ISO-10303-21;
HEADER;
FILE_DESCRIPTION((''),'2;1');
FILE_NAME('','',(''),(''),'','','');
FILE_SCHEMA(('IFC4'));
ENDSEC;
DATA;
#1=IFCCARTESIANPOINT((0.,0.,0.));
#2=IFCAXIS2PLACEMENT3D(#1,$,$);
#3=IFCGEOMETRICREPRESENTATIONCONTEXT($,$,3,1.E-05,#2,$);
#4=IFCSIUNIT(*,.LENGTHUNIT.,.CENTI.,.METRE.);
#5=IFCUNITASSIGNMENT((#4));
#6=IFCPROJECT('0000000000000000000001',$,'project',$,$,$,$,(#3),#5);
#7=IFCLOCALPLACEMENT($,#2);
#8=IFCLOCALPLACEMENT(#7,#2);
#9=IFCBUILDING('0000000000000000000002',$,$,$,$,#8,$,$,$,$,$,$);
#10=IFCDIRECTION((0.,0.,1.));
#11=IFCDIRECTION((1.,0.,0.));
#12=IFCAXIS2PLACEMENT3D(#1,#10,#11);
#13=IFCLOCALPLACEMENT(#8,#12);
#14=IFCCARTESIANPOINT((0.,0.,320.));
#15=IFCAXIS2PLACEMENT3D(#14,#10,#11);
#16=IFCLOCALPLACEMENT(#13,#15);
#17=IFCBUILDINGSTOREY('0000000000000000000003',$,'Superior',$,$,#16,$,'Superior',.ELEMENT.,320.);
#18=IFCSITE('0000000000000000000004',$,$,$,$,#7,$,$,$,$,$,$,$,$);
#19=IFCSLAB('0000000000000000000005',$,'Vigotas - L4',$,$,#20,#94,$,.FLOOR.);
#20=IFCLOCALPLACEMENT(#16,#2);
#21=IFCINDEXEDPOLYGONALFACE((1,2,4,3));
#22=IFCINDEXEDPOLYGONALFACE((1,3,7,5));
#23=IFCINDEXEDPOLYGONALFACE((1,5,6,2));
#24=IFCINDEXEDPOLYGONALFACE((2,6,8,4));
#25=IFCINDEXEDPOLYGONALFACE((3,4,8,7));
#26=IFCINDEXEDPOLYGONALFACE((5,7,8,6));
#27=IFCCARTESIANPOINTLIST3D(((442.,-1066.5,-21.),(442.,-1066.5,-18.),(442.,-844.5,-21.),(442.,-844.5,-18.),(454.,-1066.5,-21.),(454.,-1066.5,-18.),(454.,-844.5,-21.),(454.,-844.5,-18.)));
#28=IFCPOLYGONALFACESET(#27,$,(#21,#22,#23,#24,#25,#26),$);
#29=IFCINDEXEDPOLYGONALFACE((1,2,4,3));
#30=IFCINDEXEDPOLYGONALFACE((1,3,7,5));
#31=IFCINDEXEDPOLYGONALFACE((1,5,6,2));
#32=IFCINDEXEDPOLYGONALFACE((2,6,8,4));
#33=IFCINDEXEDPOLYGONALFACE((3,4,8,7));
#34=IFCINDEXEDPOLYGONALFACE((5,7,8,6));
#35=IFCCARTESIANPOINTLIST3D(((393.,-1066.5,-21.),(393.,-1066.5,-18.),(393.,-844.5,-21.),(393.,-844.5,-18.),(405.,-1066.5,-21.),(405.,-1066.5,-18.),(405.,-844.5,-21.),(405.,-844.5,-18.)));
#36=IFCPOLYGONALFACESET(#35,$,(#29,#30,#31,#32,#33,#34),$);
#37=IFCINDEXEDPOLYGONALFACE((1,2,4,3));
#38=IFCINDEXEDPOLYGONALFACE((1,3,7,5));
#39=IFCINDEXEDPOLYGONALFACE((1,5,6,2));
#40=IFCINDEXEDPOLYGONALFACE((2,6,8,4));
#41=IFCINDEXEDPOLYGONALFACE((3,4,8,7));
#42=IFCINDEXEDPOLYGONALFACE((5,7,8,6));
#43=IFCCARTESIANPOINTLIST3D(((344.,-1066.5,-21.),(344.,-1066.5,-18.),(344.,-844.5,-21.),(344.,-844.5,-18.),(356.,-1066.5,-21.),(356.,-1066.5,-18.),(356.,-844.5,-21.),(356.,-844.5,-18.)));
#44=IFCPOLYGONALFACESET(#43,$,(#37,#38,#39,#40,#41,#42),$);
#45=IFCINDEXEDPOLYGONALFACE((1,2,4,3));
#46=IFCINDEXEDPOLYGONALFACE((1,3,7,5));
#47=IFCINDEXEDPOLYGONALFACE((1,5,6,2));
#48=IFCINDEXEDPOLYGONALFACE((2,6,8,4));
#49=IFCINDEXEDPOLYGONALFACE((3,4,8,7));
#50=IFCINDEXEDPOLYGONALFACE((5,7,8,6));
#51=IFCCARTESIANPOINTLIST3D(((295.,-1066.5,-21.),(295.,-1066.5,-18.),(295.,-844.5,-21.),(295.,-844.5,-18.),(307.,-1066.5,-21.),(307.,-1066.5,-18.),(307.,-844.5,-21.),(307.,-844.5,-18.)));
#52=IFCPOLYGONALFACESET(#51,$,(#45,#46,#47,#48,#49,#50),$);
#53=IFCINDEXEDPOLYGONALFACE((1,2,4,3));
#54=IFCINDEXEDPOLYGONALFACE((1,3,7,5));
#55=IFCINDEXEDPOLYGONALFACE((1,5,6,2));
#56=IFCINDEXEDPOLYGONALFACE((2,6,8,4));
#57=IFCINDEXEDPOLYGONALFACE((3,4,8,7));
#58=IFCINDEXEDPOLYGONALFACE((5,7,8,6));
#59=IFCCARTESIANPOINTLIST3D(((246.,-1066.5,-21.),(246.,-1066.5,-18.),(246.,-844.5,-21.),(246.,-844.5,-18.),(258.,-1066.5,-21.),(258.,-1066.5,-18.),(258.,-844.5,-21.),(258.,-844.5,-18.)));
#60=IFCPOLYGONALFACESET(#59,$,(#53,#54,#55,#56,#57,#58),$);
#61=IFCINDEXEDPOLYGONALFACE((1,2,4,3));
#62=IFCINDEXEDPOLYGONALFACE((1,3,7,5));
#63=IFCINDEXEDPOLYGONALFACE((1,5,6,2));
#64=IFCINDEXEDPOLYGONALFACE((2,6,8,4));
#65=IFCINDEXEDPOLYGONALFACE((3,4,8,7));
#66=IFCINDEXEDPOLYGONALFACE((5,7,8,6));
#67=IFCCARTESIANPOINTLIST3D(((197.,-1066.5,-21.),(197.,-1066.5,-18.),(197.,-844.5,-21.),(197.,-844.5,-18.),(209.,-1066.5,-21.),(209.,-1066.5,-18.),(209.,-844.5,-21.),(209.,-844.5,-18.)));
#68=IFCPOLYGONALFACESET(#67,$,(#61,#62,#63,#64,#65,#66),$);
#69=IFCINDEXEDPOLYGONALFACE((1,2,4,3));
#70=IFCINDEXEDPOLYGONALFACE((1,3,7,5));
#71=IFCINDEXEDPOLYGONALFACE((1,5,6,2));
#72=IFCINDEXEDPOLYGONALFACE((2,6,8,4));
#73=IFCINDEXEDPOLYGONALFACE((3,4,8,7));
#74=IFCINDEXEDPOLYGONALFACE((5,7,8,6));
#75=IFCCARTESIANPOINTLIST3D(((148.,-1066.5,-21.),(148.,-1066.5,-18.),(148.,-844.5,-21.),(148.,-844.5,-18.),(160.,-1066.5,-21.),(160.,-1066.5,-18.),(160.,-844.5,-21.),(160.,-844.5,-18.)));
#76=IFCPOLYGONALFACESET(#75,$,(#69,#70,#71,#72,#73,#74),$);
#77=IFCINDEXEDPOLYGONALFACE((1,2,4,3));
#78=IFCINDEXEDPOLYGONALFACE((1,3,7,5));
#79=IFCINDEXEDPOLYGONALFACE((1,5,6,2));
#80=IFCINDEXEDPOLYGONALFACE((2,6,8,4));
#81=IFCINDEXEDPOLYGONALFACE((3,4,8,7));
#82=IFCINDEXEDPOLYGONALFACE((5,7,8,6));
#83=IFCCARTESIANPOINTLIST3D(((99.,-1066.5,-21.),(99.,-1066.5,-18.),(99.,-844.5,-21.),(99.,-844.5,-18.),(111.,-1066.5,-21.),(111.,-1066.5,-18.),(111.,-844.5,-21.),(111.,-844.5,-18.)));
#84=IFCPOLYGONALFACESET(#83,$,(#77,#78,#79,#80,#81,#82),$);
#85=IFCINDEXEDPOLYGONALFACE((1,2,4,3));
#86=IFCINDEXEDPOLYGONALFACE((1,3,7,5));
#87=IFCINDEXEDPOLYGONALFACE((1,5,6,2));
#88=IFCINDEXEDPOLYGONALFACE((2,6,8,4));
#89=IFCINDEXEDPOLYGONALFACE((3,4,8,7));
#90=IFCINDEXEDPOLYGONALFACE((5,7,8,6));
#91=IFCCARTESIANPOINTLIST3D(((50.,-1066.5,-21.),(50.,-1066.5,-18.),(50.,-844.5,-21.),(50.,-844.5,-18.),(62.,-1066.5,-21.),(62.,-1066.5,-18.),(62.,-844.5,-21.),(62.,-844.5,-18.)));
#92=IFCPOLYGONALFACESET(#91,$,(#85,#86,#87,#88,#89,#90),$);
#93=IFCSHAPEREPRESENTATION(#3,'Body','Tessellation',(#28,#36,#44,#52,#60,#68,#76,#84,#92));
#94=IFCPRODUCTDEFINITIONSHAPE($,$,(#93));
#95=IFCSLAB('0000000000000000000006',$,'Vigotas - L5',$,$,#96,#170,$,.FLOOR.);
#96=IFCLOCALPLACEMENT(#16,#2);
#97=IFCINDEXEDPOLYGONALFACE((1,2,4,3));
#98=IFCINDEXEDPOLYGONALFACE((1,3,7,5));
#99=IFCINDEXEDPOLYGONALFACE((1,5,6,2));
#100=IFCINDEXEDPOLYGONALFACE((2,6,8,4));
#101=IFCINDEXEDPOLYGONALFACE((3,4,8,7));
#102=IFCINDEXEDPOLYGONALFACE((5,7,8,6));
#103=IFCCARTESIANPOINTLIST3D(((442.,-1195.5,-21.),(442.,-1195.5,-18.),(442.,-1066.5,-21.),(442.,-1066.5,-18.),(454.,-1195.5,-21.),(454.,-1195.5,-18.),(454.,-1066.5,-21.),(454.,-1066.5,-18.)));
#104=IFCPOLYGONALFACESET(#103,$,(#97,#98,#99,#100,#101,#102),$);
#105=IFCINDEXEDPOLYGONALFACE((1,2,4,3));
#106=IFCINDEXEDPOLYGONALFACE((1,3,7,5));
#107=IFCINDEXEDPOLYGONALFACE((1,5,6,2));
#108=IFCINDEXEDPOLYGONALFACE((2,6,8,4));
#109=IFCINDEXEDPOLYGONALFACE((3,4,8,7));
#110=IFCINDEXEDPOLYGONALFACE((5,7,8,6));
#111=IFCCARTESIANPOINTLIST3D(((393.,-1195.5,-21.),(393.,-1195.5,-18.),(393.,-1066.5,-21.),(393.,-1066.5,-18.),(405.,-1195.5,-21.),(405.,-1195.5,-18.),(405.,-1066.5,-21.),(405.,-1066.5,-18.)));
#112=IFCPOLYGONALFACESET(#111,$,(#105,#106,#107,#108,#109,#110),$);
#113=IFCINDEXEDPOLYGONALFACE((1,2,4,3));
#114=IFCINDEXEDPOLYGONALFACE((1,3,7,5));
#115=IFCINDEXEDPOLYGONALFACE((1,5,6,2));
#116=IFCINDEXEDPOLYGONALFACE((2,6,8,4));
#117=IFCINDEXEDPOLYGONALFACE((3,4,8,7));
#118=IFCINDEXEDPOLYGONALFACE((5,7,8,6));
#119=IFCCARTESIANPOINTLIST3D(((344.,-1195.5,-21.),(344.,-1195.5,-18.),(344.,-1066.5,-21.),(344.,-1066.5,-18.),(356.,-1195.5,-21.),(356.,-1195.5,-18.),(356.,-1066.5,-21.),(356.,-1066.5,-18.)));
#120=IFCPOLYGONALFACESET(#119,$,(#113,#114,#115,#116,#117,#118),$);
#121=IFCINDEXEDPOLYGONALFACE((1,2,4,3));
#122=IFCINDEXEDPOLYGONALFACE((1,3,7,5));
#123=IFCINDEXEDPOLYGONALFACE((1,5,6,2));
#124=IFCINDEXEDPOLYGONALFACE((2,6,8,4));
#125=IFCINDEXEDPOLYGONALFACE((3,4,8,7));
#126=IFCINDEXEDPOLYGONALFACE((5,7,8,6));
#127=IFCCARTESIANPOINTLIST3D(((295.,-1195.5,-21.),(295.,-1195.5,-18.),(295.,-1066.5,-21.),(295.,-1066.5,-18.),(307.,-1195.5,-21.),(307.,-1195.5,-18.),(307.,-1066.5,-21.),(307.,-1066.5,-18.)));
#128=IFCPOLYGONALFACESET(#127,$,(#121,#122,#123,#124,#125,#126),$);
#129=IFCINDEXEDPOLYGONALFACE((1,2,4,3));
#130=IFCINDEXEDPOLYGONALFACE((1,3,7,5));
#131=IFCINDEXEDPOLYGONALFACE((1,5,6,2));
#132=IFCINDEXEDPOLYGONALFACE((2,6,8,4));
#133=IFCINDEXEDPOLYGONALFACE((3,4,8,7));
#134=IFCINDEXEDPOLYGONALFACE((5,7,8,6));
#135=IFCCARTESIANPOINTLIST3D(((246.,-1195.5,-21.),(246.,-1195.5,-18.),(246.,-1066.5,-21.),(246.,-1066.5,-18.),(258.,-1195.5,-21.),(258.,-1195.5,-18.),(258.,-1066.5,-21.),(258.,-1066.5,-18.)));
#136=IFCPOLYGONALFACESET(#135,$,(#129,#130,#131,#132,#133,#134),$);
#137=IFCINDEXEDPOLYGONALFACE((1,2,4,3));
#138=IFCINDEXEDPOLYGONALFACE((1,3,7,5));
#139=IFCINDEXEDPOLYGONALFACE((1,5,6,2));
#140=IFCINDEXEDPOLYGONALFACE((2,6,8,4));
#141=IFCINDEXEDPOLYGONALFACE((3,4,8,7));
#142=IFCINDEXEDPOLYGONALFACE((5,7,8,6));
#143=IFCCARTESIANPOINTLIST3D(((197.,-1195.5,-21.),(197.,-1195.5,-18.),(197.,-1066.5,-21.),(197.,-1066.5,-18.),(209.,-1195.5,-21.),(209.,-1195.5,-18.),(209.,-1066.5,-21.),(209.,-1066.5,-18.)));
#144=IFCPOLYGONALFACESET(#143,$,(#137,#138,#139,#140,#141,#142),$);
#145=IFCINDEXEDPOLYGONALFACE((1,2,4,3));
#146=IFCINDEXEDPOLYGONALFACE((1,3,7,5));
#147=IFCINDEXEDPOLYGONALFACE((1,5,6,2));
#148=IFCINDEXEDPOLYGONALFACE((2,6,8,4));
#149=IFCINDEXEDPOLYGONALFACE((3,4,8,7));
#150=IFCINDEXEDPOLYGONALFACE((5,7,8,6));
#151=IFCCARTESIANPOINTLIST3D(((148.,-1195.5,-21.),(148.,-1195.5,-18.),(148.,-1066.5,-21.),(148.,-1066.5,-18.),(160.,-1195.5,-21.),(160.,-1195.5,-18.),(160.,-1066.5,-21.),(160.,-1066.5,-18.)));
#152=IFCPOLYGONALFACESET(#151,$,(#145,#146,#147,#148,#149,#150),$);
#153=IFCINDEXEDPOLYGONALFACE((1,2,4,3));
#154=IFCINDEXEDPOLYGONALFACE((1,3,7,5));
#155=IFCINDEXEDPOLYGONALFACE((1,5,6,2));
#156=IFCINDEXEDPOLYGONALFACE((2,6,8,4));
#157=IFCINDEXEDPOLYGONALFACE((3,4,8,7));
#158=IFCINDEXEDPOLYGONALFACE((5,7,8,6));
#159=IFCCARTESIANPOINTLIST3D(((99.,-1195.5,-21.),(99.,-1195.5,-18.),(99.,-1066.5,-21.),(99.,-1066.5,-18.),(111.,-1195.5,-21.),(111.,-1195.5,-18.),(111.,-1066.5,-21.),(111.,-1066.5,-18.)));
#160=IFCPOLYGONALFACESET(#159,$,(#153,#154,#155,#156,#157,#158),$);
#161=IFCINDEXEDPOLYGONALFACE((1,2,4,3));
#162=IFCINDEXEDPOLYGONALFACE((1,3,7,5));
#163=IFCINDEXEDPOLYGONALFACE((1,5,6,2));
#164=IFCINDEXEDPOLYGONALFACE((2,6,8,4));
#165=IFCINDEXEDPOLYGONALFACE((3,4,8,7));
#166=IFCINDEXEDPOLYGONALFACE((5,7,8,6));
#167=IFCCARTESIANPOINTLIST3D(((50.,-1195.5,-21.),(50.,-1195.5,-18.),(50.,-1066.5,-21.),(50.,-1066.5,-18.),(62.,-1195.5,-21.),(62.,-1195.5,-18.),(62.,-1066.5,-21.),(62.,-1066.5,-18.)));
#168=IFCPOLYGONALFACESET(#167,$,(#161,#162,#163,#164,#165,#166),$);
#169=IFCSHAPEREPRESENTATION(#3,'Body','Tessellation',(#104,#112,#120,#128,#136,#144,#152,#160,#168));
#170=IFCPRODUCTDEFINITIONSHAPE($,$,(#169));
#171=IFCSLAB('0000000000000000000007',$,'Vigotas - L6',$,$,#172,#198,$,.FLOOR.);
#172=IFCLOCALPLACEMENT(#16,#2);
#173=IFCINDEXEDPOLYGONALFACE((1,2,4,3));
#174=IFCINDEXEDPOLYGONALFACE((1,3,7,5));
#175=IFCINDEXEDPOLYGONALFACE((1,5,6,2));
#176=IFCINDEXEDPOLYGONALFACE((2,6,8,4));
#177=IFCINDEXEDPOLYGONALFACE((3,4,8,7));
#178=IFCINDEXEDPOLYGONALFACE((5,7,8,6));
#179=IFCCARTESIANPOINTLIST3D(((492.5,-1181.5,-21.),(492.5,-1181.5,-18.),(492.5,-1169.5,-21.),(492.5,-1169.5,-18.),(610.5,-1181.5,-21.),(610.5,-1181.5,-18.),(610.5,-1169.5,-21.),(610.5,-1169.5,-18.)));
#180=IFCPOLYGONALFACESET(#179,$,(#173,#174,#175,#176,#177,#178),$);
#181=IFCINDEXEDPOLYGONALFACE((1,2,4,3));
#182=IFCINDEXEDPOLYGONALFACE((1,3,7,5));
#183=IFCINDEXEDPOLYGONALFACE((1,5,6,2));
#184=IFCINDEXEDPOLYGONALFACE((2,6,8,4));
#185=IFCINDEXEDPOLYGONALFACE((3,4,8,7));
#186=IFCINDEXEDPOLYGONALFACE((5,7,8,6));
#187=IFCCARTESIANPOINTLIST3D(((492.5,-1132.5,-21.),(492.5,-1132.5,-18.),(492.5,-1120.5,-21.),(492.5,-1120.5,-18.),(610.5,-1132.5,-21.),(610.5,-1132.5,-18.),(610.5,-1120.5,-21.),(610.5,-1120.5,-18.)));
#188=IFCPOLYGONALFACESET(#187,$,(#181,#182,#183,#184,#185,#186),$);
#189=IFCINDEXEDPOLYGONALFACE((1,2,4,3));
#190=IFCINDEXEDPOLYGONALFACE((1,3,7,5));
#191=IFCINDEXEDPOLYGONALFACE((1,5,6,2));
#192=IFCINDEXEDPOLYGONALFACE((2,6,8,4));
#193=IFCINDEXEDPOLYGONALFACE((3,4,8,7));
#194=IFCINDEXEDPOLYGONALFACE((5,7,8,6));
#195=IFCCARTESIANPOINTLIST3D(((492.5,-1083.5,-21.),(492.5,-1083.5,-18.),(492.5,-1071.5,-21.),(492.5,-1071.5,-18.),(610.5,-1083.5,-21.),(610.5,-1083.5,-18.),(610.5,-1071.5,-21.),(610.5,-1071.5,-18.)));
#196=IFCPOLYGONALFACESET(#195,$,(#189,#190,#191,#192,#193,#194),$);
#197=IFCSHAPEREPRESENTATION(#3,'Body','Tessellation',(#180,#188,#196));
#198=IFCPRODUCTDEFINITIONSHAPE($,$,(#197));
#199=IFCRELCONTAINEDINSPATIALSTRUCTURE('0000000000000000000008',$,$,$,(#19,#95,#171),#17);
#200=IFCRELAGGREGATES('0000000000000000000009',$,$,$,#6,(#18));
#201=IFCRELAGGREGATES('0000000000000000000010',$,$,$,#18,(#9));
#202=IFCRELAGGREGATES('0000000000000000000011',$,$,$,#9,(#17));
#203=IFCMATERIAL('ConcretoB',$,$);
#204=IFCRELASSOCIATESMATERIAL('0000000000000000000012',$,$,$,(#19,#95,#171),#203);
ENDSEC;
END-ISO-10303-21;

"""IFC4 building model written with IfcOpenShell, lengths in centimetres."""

from ifc_helpers import new_model, si_unit, frame, origin, origin_with_axes, place, context, project, spatial, polyline, outline, extrude, material, element, save


model = new_model("IFC4")

# Units and contexts
context_of_model = context(None, 3, precision=1e-05, world=origin())
ifc_project = project(units=[si_unit("LENGTHUNIT", "METRE", prefix="CENTI")], contexts=[context_of_model])

# Site, building, storey
site_placement = place(None, origin())
site = spatial("IfcSite", under=ifc_project, at=site_placement)
building_placement = place(site_placement, origin())
building = spatial("IfcBuilding", under=site, at=building_placement)
placement = place(building_placement, origin_with_axes())
storey_placement = place(placement, frame((0.0, 0.0, 320.0), z_axis=(0.0, 0.0, 1.0), x_axis=(1.0, 0.0, 0.0)))
storey = spatial("IfcBuildingStorey", under=building, at=storey_placement, Name="Superior", LongName="Superior", CompositionType="ELEMENT", Elevation=320.0)

# Shared definitions
ifc_material = material(Name="ConcretoB")

# Slabs
slab_1_placement = place(storey_placement, frame((252.0, -955.5, -18.0), z_axis=(0.0, 0.0, 1.0), x_axis=(1.0, 0.0, 0.0)))
element("IfcSlab", 1, at=slab_1_placement, inside=storey, material=ifc_material, Name="Vigotas - L4", PredefinedType="FLOOR", context=context_of_model, shape_type="SolidModel", body=[
    extrude(outline(polyline([(6.0, 1.5), (-6.0, 1.5), (-6.0, -1.5), (6.0, -1.5), (6.0, 1.5), (6.0, 1.5)])), frame((196.0, -111.0, -1.5), z_axis=(0.0, 1.0, 0.0), x_axis=(1.0, 0.0, 0.0)), (0.0, 0.0, 1.0), 222.0),
    extrude(outline(polyline([(6.0, 1.5), (-6.0, 1.5), (-6.0, -1.5), (6.0, -1.5), (6.0, 1.5), (6.0, 1.5)])), frame((147.0, -111.0, -1.5), z_axis=(0.0, 1.0, 0.0), x_axis=(1.0, 0.0, 0.0)), (0.0, 0.0, 1.0), 222.0),
    extrude(outline(polyline([(6.0, 1.5), (-6.0, 1.5), (-6.0, -1.5), (6.0, -1.5), (6.0, 1.5), (6.0, 1.5)])), frame((98.0, -111.0, -1.5), z_axis=(0.0, 1.0, 0.0), x_axis=(1.0, 0.0, 0.0)), (0.0, 0.0, 1.0), 222.0),
    extrude(outline(polyline([(6.0, 1.5), (-6.0, 1.5), (-6.0, -1.5), (6.0, -1.5), (6.0, 1.5), (6.0, 1.5)])), frame((49.0, -111.0, -1.5), z_axis=(0.0, 1.0, 0.0), x_axis=(1.0, 0.0, 0.0)), (0.0, 0.0, 1.0), 222.0),
    extrude(outline(polyline([(6.0, 1.5), (-6.0, 1.5), (-6.0, -1.5), (6.0, -1.5), (6.0, 1.5), (6.0, 1.5)])), frame((0.0, -111.0, -1.5), z_axis=(0.0, 1.0, 0.0), x_axis=(1.0, 0.0, 0.0)), (0.0, 0.0, 1.0), 222.0),
    extrude(outline(polyline([(6.0, 1.5), (-6.0, 1.5), (-6.0, -1.5), (6.0, -1.5), (6.0, 1.5), (6.0, 1.5)])), frame((-49.0, -111.0, -1.5), z_axis=(0.0, 1.0, 0.0), x_axis=(1.0, 0.0, 0.0)), (0.0, 0.0, 1.0), 222.0),
    extrude(outline(polyline([(6.0, 1.5), (-6.0, 1.5), (-6.0, -1.5), (6.0, -1.5), (6.0, 1.5), (6.0, 1.5)])), frame((-98.0, -111.0, -1.5), z_axis=(0.0, 1.0, 0.0), x_axis=(1.0, 0.0, 0.0)), (0.0, 0.0, 1.0), 222.0),
    extrude(outline(polyline([(6.0, 1.5), (-6.0, 1.5), (-6.0, -1.5), (6.0, -1.5), (6.0, 1.5), (6.0, 1.5)])), frame((-147.0, -111.0, -1.5), z_axis=(0.0, 1.0, 0.0), x_axis=(1.0, 0.0, 0.0)), (0.0, 0.0, 1.0), 222.0),
    extrude(outline(polyline([(6.0, 1.5), (-6.0, 1.5), (-6.0, -1.5), (6.0, -1.5), (6.0, 1.5), (6.0, 1.5)])), frame((-196.0, -111.0, -1.5), z_axis=(0.0, 1.0, 0.0), x_axis=(1.0, 0.0, 0.0)), (0.0, 0.0, 1.0), 222.0),
])
slab_2_placement = place(storey_placement, frame((252.0, -1131.0, -18.0), z_axis=(0.0, 0.0, 1.0), x_axis=(1.0, 0.0, 0.0)))
element("IfcSlab", 2, at=slab_2_placement, inside=storey, material=ifc_material, Name="Vigotas - L5", PredefinedType="FLOOR", context=context_of_model, shape_type="SolidModel", body=[
    extrude(outline(polyline([(6.0, 1.5), (-6.0, 1.5), (-6.0, -1.5), (6.0, -1.5), (6.0, 1.5), (6.0, 1.5)])), frame((196.0, -64.5, -1.5), z_axis=(0.0, 1.0, 0.0), x_axis=(1.0, 0.0, 0.0)), (0.0, 0.0, 1.0), 129.0),
    extrude(outline(polyline([(6.0, 1.5), (-6.0, 1.5), (-6.0, -1.5), (6.0, -1.5), (6.0, 1.5), (6.0, 1.5)])), frame((147.0, -64.5, -1.5), z_axis=(0.0, 1.0, 0.0), x_axis=(1.0, 0.0, 0.0)), (0.0, 0.0, 1.0), 129.0),
    extrude(outline(polyline([(6.0, 1.5), (-6.0, 1.5), (-6.0, -1.5), (6.0, -1.5), (6.0, 1.5), (6.0, 1.5)])), frame((98.0, -64.5, -1.5), z_axis=(0.0, 1.0, 0.0), x_axis=(1.0, 0.0, 0.0)), (0.0, 0.0, 1.0), 129.0),
    extrude(outline(polyline([(6.0, 1.5), (-6.0, 1.5), (-6.0, -1.5), (6.0, -1.5), (6.0, 1.5), (6.0, 1.5)])), frame((49.0, -64.5, -1.5), z_axis=(0.0, 1.0, 0.0), x_axis=(1.0, 0.0, 0.0)), (0.0, 0.0, 1.0), 129.0),
    extrude(outline(polyline([(6.0, 1.5), (-6.0, 1.5), (-6.0, -1.5), (6.0, -1.5), (6.0, 1.5), (6.0, 1.5)])), frame((0.0, -64.5, -1.5), z_axis=(0.0, 1.0, 0.0), x_axis=(1.0, 0.0, 0.0)), (0.0, 0.0, 1.0), 129.0),
    extrude(outline(polyline([(6.0, 1.5), (-6.0, 1.5), (-6.0, -1.5), (6.0, -1.5), (6.0, 1.5), (6.0, 1.5)])), frame((-49.0, -64.5, -1.5), z_axis=(0.0, 1.0, 0.0), x_axis=(1.0, 0.0, 0.0)), (0.0, 0.0, 1.0), 129.0),
    extrude(outline(polyline([(6.0, 1.5), (-6.0, 1.5), (-6.0, -1.5), (6.0, -1.5), (6.0, 1.5), (6.0, 1.5)])), frame((-98.0, -64.5, -1.5), z_axis=(0.0, 1.0, 0.0), x_axis=(1.0, 0.0, 0.0)), (0.0, 0.0, 1.0), 129.0),
    extrude(outline(polyline([(6.0, 1.5), (-6.0, 1.5), (-6.0, -1.5), (6.0, -1.5), (6.0, 1.5), (6.0, 1.5)])), frame((-147.0, -64.5, -1.5), z_axis=(0.0, 1.0, 0.0), x_axis=(1.0, 0.0, 0.0)), (0.0, 0.0, 1.0), 129.0),
    extrude(outline(polyline([(6.0, 1.5), (-6.0, 1.5), (-6.0, -1.5), (6.0, -1.5), (6.0, 1.5), (6.0, 1.5)])), frame((-196.0, -64.5, -1.5), z_axis=(0.0, 1.0, 0.0), x_axis=(1.0, 0.0, 0.0)), (0.0, 0.0, 1.0), 129.0),
])
slab_3_placement = place(storey_placement, frame((551.5, -1126.5, -18.0), z_axis=(0.0, 0.0, 1.0), x_axis=(1.0, 0.0, 0.0)))
element("IfcSlab", 3, at=slab_3_placement, inside=storey, material=ifc_material, Name="Vigotas - L6", PredefinedType="FLOOR", context=context_of_model, shape_type="SolidModel", body=[
    extrude(outline(polyline([(6.0, 1.5), (-6.0, 1.5), (-6.0, -1.5), (6.0, -1.5), (6.0, 1.5), (6.0, 1.5)])), frame((-59.0, -49.0, -1.5), z_axis=(1.0, 0.0, 0.0), x_axis=(0.0, -1.0, 0.0)), (0.0, 0.0, 1.0), 118.0),
    extrude(outline(polyline([(6.0, 1.5), (-6.0, 1.5), (-6.0, -1.5), (6.0, -1.5), (6.0, 1.5), (6.0, 1.5)])), frame((-59.0, 0.0, -1.5), z_axis=(1.0, 0.0, 0.0), x_axis=(0.0, -1.0, 0.0)), (0.0, 0.0, 1.0), 118.0),
    extrude(outline(polyline([(6.0, 1.5), (-6.0, 1.5), (-6.0, -1.5), (6.0, -1.5), (6.0, 1.5), (6.0, 1.5)])), frame((-59.0, 49.0, -1.5), z_axis=(1.0, 0.0, 0.0), x_axis=(0.0, -1.0, 0.0)), (0.0, 0.0, 1.0), 118.0),
])

save(model, "model.ifc")
